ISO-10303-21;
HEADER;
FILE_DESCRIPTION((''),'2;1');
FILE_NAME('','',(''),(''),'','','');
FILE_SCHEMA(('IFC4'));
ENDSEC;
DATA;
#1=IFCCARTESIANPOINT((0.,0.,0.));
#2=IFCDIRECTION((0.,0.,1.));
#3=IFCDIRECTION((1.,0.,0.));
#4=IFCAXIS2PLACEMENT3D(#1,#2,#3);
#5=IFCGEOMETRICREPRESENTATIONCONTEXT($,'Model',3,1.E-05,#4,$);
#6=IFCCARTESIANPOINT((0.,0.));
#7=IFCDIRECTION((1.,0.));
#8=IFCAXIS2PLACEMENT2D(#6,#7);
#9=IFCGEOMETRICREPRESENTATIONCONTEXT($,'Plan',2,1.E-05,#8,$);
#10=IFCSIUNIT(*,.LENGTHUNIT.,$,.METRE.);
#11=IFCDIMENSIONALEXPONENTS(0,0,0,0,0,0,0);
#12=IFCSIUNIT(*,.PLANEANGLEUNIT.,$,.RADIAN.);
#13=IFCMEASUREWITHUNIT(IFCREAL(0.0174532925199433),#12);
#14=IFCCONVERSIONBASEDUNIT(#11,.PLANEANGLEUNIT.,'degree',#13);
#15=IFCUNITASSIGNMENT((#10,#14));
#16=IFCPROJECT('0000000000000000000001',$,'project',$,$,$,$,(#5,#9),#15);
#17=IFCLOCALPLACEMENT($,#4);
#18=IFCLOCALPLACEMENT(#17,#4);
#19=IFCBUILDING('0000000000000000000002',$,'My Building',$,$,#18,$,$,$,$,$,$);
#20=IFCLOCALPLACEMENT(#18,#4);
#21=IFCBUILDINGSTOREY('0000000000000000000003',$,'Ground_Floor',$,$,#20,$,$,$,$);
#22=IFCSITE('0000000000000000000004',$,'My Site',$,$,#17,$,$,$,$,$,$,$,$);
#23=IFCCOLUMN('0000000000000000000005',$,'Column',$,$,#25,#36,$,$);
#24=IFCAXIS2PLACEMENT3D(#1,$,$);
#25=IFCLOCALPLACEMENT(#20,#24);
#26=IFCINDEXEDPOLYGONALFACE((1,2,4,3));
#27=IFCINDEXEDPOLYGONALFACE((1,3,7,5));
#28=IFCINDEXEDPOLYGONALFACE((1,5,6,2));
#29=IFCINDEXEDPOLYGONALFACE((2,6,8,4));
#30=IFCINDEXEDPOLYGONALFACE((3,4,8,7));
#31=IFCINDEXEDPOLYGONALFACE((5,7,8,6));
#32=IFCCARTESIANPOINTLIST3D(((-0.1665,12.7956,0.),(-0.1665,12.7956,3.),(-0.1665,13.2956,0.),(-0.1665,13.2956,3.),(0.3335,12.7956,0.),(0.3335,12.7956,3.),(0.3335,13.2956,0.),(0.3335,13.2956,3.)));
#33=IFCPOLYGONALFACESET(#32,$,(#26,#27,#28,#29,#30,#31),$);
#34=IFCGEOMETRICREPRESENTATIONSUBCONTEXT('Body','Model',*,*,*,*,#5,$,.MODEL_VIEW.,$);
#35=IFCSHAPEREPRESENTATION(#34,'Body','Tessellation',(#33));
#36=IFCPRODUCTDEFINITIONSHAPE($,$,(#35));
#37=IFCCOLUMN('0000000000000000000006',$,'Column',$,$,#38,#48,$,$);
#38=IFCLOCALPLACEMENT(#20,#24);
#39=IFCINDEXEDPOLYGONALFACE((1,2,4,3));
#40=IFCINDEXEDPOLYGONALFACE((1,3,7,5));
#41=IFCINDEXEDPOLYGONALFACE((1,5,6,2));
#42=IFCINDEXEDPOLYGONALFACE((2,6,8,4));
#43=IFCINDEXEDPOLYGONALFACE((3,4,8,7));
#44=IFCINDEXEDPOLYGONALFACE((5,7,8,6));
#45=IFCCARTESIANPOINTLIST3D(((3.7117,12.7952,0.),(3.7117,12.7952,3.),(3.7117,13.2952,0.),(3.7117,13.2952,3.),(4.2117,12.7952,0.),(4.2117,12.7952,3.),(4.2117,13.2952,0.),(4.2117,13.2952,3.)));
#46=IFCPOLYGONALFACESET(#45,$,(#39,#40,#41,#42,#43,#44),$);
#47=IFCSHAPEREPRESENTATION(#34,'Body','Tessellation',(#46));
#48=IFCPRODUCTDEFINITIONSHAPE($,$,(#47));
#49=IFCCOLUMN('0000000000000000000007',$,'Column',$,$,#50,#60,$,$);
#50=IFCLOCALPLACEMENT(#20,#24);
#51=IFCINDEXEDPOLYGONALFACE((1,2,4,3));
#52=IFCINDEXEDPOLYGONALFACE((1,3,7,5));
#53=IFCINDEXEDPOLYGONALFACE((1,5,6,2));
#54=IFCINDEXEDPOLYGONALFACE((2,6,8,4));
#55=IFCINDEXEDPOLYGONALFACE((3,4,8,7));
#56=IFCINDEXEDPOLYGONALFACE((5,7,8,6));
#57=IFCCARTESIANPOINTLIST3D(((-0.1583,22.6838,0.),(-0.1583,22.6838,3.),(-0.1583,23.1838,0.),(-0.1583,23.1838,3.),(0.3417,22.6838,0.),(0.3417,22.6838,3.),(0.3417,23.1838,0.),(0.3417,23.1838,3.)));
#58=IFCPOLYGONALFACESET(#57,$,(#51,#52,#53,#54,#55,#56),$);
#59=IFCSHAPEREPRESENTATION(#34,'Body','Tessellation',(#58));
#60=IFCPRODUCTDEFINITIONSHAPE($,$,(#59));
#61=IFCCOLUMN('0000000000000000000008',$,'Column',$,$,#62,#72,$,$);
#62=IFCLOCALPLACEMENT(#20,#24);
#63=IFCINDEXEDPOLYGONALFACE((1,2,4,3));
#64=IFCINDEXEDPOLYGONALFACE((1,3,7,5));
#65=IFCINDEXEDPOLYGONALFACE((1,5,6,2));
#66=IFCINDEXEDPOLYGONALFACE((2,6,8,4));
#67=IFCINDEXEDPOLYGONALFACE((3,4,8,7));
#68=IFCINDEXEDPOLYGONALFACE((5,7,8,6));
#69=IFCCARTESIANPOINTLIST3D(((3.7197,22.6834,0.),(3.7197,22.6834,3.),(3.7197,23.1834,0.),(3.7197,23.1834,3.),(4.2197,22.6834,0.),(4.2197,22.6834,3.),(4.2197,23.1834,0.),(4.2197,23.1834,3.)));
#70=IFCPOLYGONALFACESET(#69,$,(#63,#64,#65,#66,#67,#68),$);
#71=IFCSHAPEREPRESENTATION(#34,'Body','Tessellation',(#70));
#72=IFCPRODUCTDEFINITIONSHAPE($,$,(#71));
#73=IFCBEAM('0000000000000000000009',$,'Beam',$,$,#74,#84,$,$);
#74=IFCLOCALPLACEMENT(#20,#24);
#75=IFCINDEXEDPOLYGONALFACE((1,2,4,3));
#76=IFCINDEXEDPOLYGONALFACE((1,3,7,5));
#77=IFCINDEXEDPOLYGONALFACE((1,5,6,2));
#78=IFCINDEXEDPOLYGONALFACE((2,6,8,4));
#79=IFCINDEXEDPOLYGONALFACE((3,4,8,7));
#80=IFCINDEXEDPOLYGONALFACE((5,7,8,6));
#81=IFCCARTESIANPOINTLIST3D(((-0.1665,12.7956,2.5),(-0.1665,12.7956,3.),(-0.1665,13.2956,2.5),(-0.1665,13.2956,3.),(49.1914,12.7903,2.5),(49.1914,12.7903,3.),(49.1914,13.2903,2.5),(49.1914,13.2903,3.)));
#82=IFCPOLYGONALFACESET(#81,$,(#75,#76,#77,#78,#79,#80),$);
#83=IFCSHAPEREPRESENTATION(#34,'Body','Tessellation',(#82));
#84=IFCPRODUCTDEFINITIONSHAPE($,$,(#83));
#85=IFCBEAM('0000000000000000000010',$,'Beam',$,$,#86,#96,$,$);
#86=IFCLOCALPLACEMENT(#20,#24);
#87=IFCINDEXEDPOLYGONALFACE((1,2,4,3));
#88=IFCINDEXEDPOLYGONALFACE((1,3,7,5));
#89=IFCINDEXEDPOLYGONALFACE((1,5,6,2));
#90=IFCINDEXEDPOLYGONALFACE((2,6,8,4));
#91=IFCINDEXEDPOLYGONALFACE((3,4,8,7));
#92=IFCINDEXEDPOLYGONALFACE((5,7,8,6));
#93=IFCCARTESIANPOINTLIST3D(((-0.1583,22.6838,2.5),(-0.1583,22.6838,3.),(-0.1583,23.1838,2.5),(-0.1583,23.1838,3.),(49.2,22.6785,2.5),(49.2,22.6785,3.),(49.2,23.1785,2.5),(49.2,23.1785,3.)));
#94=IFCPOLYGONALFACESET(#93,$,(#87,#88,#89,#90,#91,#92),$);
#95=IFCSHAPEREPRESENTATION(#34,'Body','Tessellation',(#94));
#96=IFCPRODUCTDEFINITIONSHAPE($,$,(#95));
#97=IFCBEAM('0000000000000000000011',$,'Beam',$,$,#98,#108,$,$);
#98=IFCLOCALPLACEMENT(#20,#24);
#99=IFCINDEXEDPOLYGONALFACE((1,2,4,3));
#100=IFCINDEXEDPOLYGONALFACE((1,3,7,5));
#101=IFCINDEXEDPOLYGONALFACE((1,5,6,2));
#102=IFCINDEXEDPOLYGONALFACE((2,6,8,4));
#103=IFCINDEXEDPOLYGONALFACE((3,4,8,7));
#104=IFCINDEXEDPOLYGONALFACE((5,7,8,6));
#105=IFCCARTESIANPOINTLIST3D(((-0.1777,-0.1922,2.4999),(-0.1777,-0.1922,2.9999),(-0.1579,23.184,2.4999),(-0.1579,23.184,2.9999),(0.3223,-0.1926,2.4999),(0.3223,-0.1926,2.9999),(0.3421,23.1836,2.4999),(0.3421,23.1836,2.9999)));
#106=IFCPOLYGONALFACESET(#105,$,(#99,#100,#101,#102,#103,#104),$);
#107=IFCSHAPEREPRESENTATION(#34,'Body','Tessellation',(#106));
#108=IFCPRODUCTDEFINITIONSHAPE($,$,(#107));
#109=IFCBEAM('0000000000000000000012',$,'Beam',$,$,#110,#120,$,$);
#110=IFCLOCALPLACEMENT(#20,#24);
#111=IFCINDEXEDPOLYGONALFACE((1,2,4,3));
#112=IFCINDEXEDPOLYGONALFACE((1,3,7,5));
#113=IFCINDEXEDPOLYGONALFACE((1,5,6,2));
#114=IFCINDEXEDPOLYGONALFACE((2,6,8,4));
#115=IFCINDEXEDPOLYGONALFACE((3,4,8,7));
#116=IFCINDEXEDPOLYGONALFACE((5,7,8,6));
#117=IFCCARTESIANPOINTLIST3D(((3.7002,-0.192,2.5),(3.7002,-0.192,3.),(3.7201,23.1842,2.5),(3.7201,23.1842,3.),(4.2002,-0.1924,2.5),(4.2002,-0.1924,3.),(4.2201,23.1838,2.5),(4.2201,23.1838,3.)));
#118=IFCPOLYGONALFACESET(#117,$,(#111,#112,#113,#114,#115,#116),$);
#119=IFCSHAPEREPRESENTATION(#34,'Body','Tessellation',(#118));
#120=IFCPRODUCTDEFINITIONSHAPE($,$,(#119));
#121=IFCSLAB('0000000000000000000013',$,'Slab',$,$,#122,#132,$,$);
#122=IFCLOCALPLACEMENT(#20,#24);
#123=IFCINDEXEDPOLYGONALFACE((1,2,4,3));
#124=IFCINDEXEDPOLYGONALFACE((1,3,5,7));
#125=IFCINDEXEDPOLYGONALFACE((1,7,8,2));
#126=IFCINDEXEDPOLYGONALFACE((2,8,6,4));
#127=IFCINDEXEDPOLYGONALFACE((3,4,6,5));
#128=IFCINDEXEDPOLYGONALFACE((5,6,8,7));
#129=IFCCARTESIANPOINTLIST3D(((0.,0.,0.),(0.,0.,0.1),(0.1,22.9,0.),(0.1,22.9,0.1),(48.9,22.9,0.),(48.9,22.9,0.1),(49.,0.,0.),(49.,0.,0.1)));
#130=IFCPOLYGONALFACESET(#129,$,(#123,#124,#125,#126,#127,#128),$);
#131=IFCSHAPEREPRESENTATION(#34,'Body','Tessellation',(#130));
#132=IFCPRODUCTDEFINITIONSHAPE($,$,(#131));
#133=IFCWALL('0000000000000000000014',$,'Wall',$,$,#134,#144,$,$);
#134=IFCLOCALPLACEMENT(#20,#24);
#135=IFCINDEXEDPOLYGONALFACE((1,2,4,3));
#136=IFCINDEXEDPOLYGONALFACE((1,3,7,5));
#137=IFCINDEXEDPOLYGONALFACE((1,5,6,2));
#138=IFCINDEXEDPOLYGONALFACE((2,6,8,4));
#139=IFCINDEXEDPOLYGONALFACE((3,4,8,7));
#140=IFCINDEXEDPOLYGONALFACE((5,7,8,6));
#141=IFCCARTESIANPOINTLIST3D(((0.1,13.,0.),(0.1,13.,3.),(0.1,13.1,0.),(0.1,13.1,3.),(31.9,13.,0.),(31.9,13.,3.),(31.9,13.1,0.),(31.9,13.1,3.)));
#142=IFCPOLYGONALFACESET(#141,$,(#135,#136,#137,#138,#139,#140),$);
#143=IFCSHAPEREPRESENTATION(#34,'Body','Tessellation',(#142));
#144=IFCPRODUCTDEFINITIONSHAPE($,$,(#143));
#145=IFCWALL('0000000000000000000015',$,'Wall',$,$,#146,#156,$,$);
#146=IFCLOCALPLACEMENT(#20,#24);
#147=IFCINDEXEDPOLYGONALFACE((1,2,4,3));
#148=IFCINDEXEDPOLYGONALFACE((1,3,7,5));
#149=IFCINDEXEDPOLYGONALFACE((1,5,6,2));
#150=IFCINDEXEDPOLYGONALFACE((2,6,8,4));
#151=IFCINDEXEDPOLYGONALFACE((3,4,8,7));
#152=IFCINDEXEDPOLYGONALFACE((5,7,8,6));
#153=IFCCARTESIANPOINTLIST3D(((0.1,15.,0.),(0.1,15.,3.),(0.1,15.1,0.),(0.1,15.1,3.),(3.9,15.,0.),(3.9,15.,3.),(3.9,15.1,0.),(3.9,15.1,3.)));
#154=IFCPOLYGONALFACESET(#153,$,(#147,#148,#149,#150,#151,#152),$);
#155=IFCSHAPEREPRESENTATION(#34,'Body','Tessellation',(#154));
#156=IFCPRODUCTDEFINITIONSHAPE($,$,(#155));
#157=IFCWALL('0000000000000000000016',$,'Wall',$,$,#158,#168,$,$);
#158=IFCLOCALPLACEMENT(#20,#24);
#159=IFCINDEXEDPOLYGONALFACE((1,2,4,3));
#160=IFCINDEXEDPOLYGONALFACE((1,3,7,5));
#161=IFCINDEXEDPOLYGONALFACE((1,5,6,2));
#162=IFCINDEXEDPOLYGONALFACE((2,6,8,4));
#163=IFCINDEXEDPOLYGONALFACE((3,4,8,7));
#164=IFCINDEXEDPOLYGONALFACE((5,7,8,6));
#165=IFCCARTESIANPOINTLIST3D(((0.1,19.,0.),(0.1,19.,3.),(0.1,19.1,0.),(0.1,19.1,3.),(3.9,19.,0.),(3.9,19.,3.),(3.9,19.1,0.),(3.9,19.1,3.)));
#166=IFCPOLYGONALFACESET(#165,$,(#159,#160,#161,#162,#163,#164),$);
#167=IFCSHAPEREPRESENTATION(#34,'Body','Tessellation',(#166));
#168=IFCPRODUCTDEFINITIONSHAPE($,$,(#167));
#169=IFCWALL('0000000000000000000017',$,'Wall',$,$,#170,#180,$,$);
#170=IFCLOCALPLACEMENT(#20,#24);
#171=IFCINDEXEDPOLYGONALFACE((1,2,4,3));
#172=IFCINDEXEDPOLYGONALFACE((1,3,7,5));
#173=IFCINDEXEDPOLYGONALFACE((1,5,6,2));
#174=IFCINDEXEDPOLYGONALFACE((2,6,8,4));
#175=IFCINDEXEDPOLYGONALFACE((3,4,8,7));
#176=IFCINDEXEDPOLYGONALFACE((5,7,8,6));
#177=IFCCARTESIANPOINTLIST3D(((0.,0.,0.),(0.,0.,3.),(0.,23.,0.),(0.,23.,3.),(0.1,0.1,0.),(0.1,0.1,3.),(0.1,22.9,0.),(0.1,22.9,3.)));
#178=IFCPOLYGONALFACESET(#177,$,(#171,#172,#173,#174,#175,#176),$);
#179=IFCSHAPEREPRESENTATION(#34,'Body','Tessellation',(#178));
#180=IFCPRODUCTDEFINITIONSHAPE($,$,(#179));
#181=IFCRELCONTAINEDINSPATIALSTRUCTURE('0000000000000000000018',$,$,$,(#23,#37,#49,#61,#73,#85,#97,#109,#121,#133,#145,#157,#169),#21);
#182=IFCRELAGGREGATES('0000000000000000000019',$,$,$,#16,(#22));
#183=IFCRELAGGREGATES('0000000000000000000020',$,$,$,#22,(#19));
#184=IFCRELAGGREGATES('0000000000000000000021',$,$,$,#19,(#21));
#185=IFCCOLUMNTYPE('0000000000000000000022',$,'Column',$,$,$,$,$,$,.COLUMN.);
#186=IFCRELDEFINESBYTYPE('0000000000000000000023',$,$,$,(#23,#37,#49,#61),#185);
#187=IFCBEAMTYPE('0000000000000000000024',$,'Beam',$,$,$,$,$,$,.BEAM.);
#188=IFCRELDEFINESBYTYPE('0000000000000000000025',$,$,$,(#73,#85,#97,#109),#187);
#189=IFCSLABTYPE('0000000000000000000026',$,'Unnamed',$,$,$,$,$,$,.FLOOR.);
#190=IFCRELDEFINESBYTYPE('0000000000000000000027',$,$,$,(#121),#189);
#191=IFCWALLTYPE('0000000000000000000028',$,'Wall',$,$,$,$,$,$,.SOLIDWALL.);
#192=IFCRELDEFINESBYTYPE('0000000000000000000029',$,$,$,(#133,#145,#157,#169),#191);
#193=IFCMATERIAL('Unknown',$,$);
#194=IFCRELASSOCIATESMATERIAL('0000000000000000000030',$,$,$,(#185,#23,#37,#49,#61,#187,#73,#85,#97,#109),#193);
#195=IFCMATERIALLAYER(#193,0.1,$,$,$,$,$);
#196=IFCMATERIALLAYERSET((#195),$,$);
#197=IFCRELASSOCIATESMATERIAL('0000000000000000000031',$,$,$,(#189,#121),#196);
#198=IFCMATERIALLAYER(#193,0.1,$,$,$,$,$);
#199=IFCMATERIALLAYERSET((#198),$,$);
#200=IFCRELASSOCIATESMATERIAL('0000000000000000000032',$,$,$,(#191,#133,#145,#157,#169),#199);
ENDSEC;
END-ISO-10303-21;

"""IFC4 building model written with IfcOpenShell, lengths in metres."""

from ifc_helpers import new_model, entity, si_unit, converted_unit, frame, origin_with_axes, origin_2d_with_axis, place, context, subcontext, project, spatial, line, indexed_curve, rectangle, outline, extrude, material, layer, layer_set, layer_usage, material_profile, profile_set, profile_usage, type_object, element, save


model = new_model("IFC4")

# Units and contexts
model_context = context("Model", 3, precision=1e-05, world=origin_with_axes())
plan_context = context("Plan", 2, precision=1e-05, world=origin_2d_with_axis())
body_context = subcontext(model_context, "Body", "Model", "MODEL_VIEW")
ifc_project = project(units=[si_unit("LENGTHUNIT", "METRE"), converted_unit("PLANEANGLEUNIT", "degree", entity("IfcReal", 0.0174532925199433), si_unit("PLANEANGLEUNIT", "RADIAN"), dimensions=[0, 0, 0, 0, 0, 0, 0])], contexts=[model_context, plan_context])

# Site, building, storey
site_placement = place(None, origin_with_axes())
site = spatial("IfcSite", under=ifc_project, at=site_placement, Name="My Site")
building_placement = place(site_placement, origin_with_axes())
building = spatial("IfcBuilding", under=site, at=building_placement, Name="My Building")
storey_placement = place(building_placement, origin_with_axes())
storey = spatial("IfcBuildingStorey", under=building, at=storey_placement, Name="Ground_Floor")

# Columns
ifc_material = material(Name="Unknown")
ifc_material_profile_1 = material_profile(ifc_material, rectangle(XDim=0.5, YDim=0.5))
ifc_profile_set_1 = profile_set([ifc_material_profile_1])
ifc_profile_usage_1 = profile_usage(ifc_profile_set_1, cardinal=5)
column_type = type_object("IfcColumnType", Name="Column", PredefinedType="COLUMN", material=ifc_profile_set_1)
column_1_placement = place(storey_placement, frame((0.0835, 13.0456, 0.0), z_axis=(0.0, 0.0, 1.0), x_axis=(1.0, 0.0, 0.0)))
element("IfcColumn", 1, at=column_1_placement, inside=storey, type_object=column_type, material=ifc_profile_usage_1, Name="Column", context=body_context, shape_type="SweptSolid", body=[
    extrude(rectangle(XDim=0.5, YDim=0.5), origin_with_axes(), (0.0, 0.0, 1.0), 3.0),
])
ifc_profile_usage_2 = profile_usage(ifc_profile_set_1, cardinal=5)
column_2_placement = place(storey_placement, frame((3.9617, 13.0452, 0.0), z_axis=(0.0, 0.0, 1.0), x_axis=(1.0, 0.0, 0.0)))
element("IfcColumn", 2, at=column_2_placement, inside=storey, type_object=column_type, material=ifc_profile_usage_2, Name="Column", context=body_context, shape_type="SweptSolid", body=[
    extrude(rectangle(XDim=0.5, YDim=0.5), origin_with_axes(), (0.0, 0.0, 1.0), 3.0),
])
ifc_profile_usage_3 = profile_usage(ifc_profile_set_1, cardinal=5)
column_3_placement = place(storey_placement, frame((0.0917, 22.9338, 0.0), z_axis=(0.0, 0.0, 1.0), x_axis=(1.0, 0.0, 0.0)))
element("IfcColumn", 3, at=column_3_placement, inside=storey, type_object=column_type, material=ifc_profile_usage_3, Name="Column", context=body_context, shape_type="SweptSolid", body=[
    extrude(rectangle(XDim=0.5, YDim=0.5), origin_with_axes(), (0.0, 0.0, 1.0), 3.0),
])
ifc_profile_usage_4 = profile_usage(ifc_profile_set_1, cardinal=5)
column_4_placement = place(storey_placement, frame((3.9697, 22.9334, 0.0), z_axis=(0.0, 0.0, 1.0), x_axis=(1.0, 0.0, 0.0)))
element("IfcColumn", 4, at=column_4_placement, inside=storey, type_object=column_type, material=ifc_profile_usage_4, Name="Column", context=body_context, shape_type="SweptSolid", body=[
    extrude(rectangle(XDim=0.5, YDim=0.5), origin_with_axes(), (0.0, 0.0, 1.0), 3.0),
])

# Beams
ifc_material_profile_2 = material_profile(ifc_material, rectangle(XDim=0.5, YDim=0.5))
ifc_profile_set_2 = profile_set([ifc_material_profile_2])
ifc_profile_usage_5 = profile_usage(ifc_profile_set_2, cardinal=5)
beam_type = type_object("IfcBeamType", Name="Beam", PredefinedType="BEAM", material=ifc_profile_set_2)
beam_1_placement = place(storey_placement, frame((-0.1665, 13.0456, 2.75), z_axis=(1.0, -0.000107, 0.0), x_axis=(0.000107, 1.0, 0.0)))
element("IfcBeam", 5, at=beam_1_placement, inside=storey, type_object=beam_type, material=ifc_profile_usage_5, Name="Beam", context=body_context, shape_type="SweptSolid", body=[
    extrude(rectangle(XDim=0.5, YDim=0.5), origin_with_axes(), (0.0, 0.0, 1.0), 49.3579),
])
ifc_profile_usage_6 = profile_usage(ifc_profile_set_2, cardinal=5)
beam_2_placement = place(storey_placement, frame((-0.1583, 22.9338, 2.75), z_axis=(1.0, -0.000107, 0.0), x_axis=(0.000107, 1.0, 0.0)))
element("IfcBeam", 6, at=beam_2_placement, inside=storey, type_object=beam_type, material=ifc_profile_usage_6, Name="Beam", context=body_context, shape_type="SweptSolid", body=[
    extrude(rectangle(XDim=0.5, YDim=0.5), origin_with_axes(), (0.0, 0.0, 1.0), 49.3583),
])
ifc_profile_usage_7 = profile_usage(ifc_profile_set_2, cardinal=5)
beam_3_placement = place(storey_placement, frame((0.0921, 23.1838, 2.7499), z_axis=(-0.000849, -1.0, 0.0), x_axis=(1.0, -0.000849, 0.0)))
element("IfcBeam", 7, at=beam_3_placement, inside=storey, type_object=beam_type, material=ifc_profile_usage_7, Name="Beam", context=body_context, shape_type="SweptSolid", body=[
    extrude(rectangle(XDim=0.5, YDim=0.5), origin_with_axes(), (0.0, 0.0, 1.0), 23.3762),
])
ifc_profile_usage_8 = profile_usage(ifc_profile_set_2, cardinal=5)
beam_4_placement = place(storey_placement, frame((3.9701, 23.184, 2.75), z_axis=(-0.000849, -1.0, 0.0), x_axis=(1.0, -0.000849, 0.0)))
element("IfcBeam", 8, at=beam_4_placement, inside=storey, type_object=beam_type, material=ifc_profile_usage_8, Name="Beam", context=body_context, shape_type="SweptSolid", body=[
    extrude(rectangle(XDim=0.5, YDim=0.5), origin_with_axes(), (0.0, 0.0, 1.0), 23.3762),
])

# Slab
ifc_layer_1 = layer(ifc_material, 0.1)
ifc_layer_set_1 = layer_set([ifc_layer_1])
ifc_layer_usage_1 = layer_usage(ifc_layer_set_1, "AXIS3", "POSITIVE", -0.1)
slab_type = type_object("IfcSlabType", Name="Unnamed", PredefinedType="FLOOR", material=ifc_layer_set_1)
slab_placement = place(storey_placement, frame((0.1, 22.9, 0.1), z_axis=(0.0, 0.0, 1.0), x_axis=(1.0, 0.0, 0.0)))
element("IfcSlab", 9, at=slab_placement, inside=storey, type_object=slab_type, material=ifc_layer_usage_1, Name="Slab", context=body_context, shape_type="SweptSolid", body=[
    extrude(outline(indexed_curve([(0.0, 0.0), (48.8, 0.0), (48.9, -22.9), (-0.1, -22.9), (0.0, 0.0)])), frame((0.0, 0.0, -0.1), z_axis=(0.0, 0.0, 1.0), x_axis=(1.0, 0.0, 0.0)), (0.0, 0.0, 1.0), 0.1),
])

# Walls
ifc_layer_2 = layer(ifc_material, 0.1)
ifc_layer_set_2 = layer_set([ifc_layer_2])
ifc_layer_usage_2 = layer_usage(ifc_layer_set_2, "AXIS2", "POSITIVE", 0.0)
wall_type = type_object("IfcWallType", Name="Wall", PredefinedType="SOLIDWALL", material=ifc_layer_set_2)
wall_1_placement = place(storey_placement, frame((0.0, 13.0, 0.0), z_axis=(0.0, 0.0, 1.0), x_axis=(1.0, 0.0, 0.0)))
element("IfcWall", 10, at=wall_1_placement, inside=storey, type_object=wall_type, material=ifc_layer_usage_2, Name="Wall", context=body_context, shape_type="SweptSolid", body=[
    extrude(outline(indexed_curve([(0.1, 0.0), (0.1, 0.1), (31.9, 0.1), (31.9, 0.0)], segments=[line(1, 2, 3, 4, 1)])), origin_with_axes(), (0.0, 0.0, 1.0), 3.0),
])
ifc_layer_usage_3 = layer_usage(ifc_layer_set_2, "AXIS2", "POSITIVE", 0.0)
wall_2_placement = place(storey_placement, frame((0.0, 15.0, 0.0), z_axis=(0.0, 0.0, 1.0), x_axis=(1.0, 0.0, 0.0)))
element("IfcWall", 11, at=wall_2_placement, inside=storey, type_object=wall_type, material=ifc_layer_usage_3, Name="Wall", context=body_context, shape_type="SweptSolid", body=[
    extrude(outline(indexed_curve([(0.1, 0.0), (0.1, 0.1), (3.9, 0.1), (3.9, 0.0)], segments=[line(1, 2, 3, 4, 1)])), origin_with_axes(), (0.0, 0.0, 1.0), 3.0),
])
ifc_layer_usage_4 = layer_usage(ifc_layer_set_2, "AXIS2", "POSITIVE", 0.0)
wall_3_placement = place(storey_placement, frame((0.0, 19.0, 0.0), z_axis=(0.0, 0.0, 1.0), x_axis=(1.0, 0.0, 0.0)))
element("IfcWall", 12, at=wall_3_placement, inside=storey, type_object=wall_type, material=ifc_layer_usage_4, Name="Wall", context=body_context, shape_type="SweptSolid", body=[
    extrude(outline(indexed_curve([(0.1, 0.0), (0.1, 0.1), (3.9, 0.1), (3.9, 0.0)], segments=[line(1, 2, 3, 4, 1)])), origin_with_axes(), (0.0, 0.0, 1.0), 3.0),
])
ifc_layer_usage_5 = layer_usage(ifc_layer_set_2, "AXIS2", "POSITIVE", 0.0)
wall_4_placement = place(storey_placement, frame((0.0, 23.0, 0.0), z_axis=(0.0, 0.0, 1.0), x_axis=(0.0, -1.0, 0.0)))
element("IfcWall", 13, at=wall_4_placement, inside=storey, type_object=wall_type, material=ifc_layer_usage_5, Name="Wall", context=body_context, shape_type="SweptSolid", body=[
    extrude(outline(indexed_curve([(0.0, 0.0), (0.1, 0.1), (22.9, 0.1), (23.0, 0.0)], segments=[line(1, 2, 3, 4, 1)])), origin_with_axes(), (0.0, 0.0, 1.0), 3.0),
])

save(model, "model.ifc")
